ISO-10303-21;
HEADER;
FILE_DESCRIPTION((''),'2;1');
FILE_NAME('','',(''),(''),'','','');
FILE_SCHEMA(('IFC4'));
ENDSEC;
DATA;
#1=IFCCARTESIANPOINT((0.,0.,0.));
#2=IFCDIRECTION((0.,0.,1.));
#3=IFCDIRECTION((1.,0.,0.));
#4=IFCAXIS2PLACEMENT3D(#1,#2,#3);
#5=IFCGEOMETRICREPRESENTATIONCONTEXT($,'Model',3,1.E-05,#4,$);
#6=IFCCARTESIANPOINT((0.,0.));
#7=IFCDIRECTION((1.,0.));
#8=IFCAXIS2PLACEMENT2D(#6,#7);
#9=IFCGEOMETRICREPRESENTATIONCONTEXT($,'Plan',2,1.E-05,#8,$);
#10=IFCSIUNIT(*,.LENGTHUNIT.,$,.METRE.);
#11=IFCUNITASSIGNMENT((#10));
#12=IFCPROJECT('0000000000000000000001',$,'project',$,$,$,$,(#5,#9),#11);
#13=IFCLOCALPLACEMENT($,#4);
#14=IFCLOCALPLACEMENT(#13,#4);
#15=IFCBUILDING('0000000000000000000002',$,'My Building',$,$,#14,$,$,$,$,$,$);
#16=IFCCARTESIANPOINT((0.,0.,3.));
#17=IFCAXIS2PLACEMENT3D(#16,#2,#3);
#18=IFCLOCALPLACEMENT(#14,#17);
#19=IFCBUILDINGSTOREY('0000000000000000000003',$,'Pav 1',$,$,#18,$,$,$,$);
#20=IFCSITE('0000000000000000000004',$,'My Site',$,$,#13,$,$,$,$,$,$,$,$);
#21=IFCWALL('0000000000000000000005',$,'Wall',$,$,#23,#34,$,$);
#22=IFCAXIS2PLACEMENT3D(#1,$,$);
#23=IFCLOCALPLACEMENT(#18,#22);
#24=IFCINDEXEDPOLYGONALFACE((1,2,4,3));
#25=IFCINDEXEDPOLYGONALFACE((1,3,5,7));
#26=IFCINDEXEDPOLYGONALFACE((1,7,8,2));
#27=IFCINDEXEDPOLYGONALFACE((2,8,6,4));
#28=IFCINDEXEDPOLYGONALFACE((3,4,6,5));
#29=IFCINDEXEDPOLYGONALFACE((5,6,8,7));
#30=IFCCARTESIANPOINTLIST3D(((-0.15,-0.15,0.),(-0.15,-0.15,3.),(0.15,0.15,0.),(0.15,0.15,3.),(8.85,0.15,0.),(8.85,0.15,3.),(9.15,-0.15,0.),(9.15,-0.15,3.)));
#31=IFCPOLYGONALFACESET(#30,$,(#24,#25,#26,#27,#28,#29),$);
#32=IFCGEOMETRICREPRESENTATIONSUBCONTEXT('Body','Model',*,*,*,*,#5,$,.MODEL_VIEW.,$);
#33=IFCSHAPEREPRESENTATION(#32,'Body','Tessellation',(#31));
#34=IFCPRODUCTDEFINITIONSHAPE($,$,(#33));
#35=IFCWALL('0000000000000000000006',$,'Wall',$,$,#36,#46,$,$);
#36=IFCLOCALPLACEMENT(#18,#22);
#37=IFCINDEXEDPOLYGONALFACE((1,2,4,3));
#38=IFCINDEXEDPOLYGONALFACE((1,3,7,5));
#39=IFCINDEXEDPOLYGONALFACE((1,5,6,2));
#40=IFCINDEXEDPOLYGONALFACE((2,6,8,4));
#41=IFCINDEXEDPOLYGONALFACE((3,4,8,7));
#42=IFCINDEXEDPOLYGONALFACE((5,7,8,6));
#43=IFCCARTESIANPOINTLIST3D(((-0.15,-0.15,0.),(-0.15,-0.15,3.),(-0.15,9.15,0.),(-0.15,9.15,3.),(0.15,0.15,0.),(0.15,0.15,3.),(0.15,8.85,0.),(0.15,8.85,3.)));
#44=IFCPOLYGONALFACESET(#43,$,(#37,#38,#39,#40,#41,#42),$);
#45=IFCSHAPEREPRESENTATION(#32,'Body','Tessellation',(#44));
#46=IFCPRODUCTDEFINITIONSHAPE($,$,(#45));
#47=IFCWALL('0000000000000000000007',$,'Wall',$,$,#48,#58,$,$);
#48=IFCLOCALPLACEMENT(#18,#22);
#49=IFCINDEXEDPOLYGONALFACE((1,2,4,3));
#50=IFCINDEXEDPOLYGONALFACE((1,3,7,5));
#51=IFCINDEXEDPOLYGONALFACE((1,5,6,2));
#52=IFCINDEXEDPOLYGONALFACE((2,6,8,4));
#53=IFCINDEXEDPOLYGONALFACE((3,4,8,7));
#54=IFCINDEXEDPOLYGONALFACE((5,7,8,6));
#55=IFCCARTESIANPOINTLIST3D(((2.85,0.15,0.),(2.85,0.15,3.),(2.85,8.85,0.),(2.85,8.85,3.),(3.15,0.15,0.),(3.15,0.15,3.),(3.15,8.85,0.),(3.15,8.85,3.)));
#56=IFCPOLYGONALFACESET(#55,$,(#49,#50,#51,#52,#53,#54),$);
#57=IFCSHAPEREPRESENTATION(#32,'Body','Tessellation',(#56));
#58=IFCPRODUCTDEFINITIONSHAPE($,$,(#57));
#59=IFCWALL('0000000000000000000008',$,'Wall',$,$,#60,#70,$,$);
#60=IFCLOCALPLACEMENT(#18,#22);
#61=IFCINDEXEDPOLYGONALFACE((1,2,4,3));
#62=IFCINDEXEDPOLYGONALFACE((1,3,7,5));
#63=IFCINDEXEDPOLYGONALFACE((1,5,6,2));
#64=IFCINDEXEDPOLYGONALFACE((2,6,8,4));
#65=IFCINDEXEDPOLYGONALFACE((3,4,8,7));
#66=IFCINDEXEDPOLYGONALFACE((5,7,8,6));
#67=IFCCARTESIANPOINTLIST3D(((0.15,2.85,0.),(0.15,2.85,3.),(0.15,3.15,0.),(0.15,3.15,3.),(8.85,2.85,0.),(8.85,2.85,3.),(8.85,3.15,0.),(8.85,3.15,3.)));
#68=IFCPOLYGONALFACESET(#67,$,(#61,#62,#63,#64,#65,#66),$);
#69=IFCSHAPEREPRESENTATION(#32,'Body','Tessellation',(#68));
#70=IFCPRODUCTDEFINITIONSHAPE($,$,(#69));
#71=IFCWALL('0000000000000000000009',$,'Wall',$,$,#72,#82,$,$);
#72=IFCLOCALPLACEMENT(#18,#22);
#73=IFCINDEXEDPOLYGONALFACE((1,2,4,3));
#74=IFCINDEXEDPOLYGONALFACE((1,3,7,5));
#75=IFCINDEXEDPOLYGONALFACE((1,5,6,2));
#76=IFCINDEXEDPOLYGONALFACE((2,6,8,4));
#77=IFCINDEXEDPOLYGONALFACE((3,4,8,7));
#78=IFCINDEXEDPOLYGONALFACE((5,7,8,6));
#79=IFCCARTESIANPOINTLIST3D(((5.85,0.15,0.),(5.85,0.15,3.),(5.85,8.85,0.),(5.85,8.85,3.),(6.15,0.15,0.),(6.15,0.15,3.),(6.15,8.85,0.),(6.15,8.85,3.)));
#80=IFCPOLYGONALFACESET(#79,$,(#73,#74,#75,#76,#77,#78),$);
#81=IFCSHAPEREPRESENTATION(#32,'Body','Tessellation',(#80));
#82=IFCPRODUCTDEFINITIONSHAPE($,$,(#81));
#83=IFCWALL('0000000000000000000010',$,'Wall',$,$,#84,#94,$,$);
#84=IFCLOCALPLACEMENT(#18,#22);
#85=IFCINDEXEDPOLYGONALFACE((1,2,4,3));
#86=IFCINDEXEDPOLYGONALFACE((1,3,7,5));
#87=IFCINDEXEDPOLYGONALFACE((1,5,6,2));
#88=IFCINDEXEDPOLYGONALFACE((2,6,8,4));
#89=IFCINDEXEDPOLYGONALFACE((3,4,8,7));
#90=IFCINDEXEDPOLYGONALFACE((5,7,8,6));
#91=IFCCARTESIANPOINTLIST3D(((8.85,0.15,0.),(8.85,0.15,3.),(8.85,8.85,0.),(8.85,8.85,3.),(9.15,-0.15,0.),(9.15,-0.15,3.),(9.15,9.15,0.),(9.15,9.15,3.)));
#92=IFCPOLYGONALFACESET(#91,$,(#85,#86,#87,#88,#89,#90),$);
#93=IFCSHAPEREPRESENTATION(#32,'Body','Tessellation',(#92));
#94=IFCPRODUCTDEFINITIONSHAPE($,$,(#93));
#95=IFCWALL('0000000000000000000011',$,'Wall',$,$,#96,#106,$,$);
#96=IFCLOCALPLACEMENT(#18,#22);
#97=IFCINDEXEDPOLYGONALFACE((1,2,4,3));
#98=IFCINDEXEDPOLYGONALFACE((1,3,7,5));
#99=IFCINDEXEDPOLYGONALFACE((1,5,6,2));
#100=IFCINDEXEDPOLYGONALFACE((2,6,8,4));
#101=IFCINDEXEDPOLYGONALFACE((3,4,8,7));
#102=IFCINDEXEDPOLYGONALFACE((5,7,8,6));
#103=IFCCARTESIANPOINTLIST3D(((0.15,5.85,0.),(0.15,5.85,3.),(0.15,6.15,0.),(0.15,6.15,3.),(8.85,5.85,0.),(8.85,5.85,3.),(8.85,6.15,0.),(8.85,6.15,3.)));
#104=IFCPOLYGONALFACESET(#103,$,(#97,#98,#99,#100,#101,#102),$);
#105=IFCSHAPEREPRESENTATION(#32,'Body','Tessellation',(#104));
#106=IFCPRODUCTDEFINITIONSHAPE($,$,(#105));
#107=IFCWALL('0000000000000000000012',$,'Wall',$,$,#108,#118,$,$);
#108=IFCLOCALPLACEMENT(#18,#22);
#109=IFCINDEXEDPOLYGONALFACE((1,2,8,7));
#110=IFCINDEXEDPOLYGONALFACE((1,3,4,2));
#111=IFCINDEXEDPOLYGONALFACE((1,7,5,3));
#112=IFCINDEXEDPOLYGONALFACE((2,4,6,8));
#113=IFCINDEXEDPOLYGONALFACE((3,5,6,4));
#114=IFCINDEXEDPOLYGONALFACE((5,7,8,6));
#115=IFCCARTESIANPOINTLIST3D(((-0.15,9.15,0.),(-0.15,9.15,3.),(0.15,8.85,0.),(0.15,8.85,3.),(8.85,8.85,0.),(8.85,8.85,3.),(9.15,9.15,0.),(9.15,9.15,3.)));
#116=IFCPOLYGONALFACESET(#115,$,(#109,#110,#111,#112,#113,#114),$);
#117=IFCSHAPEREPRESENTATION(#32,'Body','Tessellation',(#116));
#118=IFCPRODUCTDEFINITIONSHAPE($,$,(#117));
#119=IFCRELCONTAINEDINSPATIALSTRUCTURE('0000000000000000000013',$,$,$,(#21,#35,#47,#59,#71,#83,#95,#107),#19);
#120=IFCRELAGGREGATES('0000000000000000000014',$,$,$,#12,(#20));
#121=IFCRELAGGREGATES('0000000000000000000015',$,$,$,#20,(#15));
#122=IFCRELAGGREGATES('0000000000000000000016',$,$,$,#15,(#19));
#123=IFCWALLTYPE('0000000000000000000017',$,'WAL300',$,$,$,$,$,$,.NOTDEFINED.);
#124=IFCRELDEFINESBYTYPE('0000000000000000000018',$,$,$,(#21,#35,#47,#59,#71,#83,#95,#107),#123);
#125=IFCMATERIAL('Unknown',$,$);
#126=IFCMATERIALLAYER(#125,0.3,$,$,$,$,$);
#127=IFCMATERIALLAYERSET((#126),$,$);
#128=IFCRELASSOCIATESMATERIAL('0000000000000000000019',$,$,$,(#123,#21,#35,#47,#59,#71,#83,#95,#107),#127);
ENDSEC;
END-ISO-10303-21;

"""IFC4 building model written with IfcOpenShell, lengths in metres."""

from ifc_helpers import new_model, si_unit, frame, origin_with_axes, origin_2d_with_axis, place, context, subcontext, project, spatial, line, indexed_curve, outline, extrude, material, layer, layer_set, layer_usage, type_object, element, save


model = new_model("IFC4")

# Units and contexts
model_context = context("Model", 3, precision=1e-05, world=origin_with_axes())
plan_context = context("Plan", 2, precision=1e-05, world=origin_2d_with_axis())
body_context = subcontext(model_context, "Body", "Model", "MODEL_VIEW")
ifc_project = project(units=[si_unit("LENGTHUNIT", "METRE")], contexts=[model_context, plan_context])

# Site, building, storey
site_placement = place(None, origin_with_axes())
site = spatial("IfcSite", under=ifc_project, at=site_placement, Name="My Site")
building_placement = place(site_placement, origin_with_axes())
building = spatial("IfcBuilding", under=site, at=building_placement, Name="My Building")
storey_placement = place(building_placement, frame((0.0, 0.0, 3.0), z_axis=(0.0, 0.0, 1.0), x_axis=(1.0, 0.0, 0.0)))
storey = spatial("IfcBuildingStorey", under=building, at=storey_placement, Name="Pav 1")

# Shared definitions
ifc_material = material(Name="Unknown")

# Walls
ifc_layer_1 = layer(ifc_material, 0.3)
ifc_layer_set_1 = layer_set([ifc_layer_1])
ifc_layer_usage_1 = layer_usage(ifc_layer_set_1, "AXIS2", "POSITIVE", -0.15)
wall_type = type_object("IfcWallType", Name="WAL300", PredefinedType="NOTDEFINED", material=ifc_layer_set_1)
wall_1_placement = place(storey_placement, frame((9.0, 0.0, 0.0), z_axis=(0.0, 0.0, 1.0), x_axis=(-1.0, 0.0, 0.0)))
element("IfcWall", 1, at=wall_1_placement, inside=storey, type_object=wall_type, material=ifc_layer_usage_1, Name="Wall", context=body_context, shape_type="SweptSolid", body=[
    extrude(outline(indexed_curve([(0.15, -0.15), (-0.15, 0.15), (9.15, 0.15), (8.85, -0.15)], segments=[line(1, 2, 3, 4, 1)])), origin_with_axes(), (0.0, 0.0, 1.0), 3.0),
])
ifc_layer_usage_2 = layer_usage(ifc_layer_set_1, "AXIS2", "POSITIVE", -0.15)
wall_2_placement = place(storey_placement, frame((0.0, 0.0, 0.0), z_axis=(0.0, 0.0, 1.0), x_axis=(0.0, 1.0, 0.0)))
element("IfcWall", 2, at=wall_2_placement, inside=storey, type_object=wall_type, material=ifc_layer_usage_2, Name="Wall", context=body_context, shape_type="SweptSolid", body=[
    extrude(outline(indexed_curve([(0.15, -0.15), (-0.15, 0.15), (9.15, 0.15), (8.85, -0.15)], segments=[line(1, 2, 3, 4, 1)])), origin_with_axes(), (0.0, 0.0, 1.0), 3.0),
])
ifc_layer_usage_3 = layer_usage(ifc_layer_set_1, "AXIS2", "POSITIVE", -0.15)
wall_3_placement = place(storey_placement, frame((3.0, 9.0, 0.0), z_axis=(0.0, 0.0, 1.0), x_axis=(0.0, -1.0, 0.0)))
element("IfcWall", 3, at=wall_3_placement, inside=storey, type_object=wall_type, material=ifc_layer_usage_3, Name="Wall", context=body_context, shape_type="SweptSolid", body=[
    extrude(outline(indexed_curve([(0.15, -0.15), (0.15, 0.15), (8.85, 0.15), (8.85, -0.15)], segments=[line(1, 2, 3, 4, 1)])), origin_with_axes(), (0.0, 0.0, 1.0), 3.0),
])
ifc_layer_usage_4 = layer_usage(ifc_layer_set_1, "AXIS2", "POSITIVE", -0.15)
wall_4_placement = place(storey_placement, frame((0.0, 3.0, 0.0), z_axis=(0.0, 0.0, 1.0), x_axis=(1.0, 0.0, 0.0)))
element("IfcWall", 4, at=wall_4_placement, inside=storey, type_object=wall_type, material=ifc_layer_usage_4, Name="Wall", context=body_context, shape_type="SweptSolid", body=[
    extrude(outline(indexed_curve([(0.15, -0.15), (0.15, 0.15), (8.85, 0.15), (8.85, -0.15)], segments=[line(1, 2, 3, 4, 1)])), origin_with_axes(), (0.0, 0.0, 1.0), 3.0),
])
ifc_layer_usage_5 = layer_usage(ifc_layer_set_1, "AXIS2", "POSITIVE", -0.15)
wall_5_placement = place(storey_placement, frame((6.0, 9.0, 0.0), z_axis=(0.0, 0.0, 1.0), x_axis=(0.0, -1.0, 0.0)))
element("IfcWall", 5, at=wall_5_placement, inside=storey, type_object=wall_type, material=ifc_layer_usage_5, Name="Wall", context=body_context, shape_type="SweptSolid", body=[
    extrude(outline(indexed_curve([(0.15, -0.15), (0.15, 0.15), (8.85, 0.15), (8.85, -0.15)], segments=[line(1, 2, 3, 4, 1)])), origin_with_axes(), (0.0, 0.0, 1.0), 3.0),
])
ifc_layer_usage_6 = layer_usage(ifc_layer_set_1, "AXIS2", "POSITIVE", -0.15)
wall_6_placement = place(storey_placement, frame((9.0, 9.0, 0.0), z_axis=(0.0, 0.0, 1.0), x_axis=(0.0, -1.0, 0.0)))
element("IfcWall", 6, at=wall_6_placement, inside=storey, type_object=wall_type, material=ifc_layer_usage_6, Name="Wall", context=body_context, shape_type="SweptSolid", body=[
    extrude(outline(indexed_curve([(0.15, -0.15), (-0.15, 0.15), (9.15, 0.15), (8.85, -0.15)], segments=[line(1, 2, 3, 4, 1)])), origin_with_axes(), (0.0, 0.0, 1.0), 3.0),
])
ifc_layer_usage_7 = layer_usage(ifc_layer_set_1, "AXIS2", "POSITIVE", -0.15)
wall_7_placement = place(storey_placement, frame((0.0, 6.0, 0.0), z_axis=(0.0, 0.0, 1.0), x_axis=(1.0, 0.0, 0.0)))
element("IfcWall", 7, at=wall_7_placement, inside=storey, type_object=wall_type, material=ifc_layer_usage_7, Name="Wall", context=body_context, shape_type="SweptSolid", body=[
    extrude(outline(indexed_curve([(0.15, -0.15), (0.15, 0.15), (8.85, 0.15), (8.85, -0.15)], segments=[line(1, 2, 3, 4, 1)])), origin_with_axes(), (0.0, 0.0, 1.0), 3.0),
])
ifc_layer_usage_8 = layer_usage(ifc_layer_set_1, "AXIS2", "POSITIVE", -0.15)
wall_8_placement = place(storey_placement, frame((0.0, 9.0, 0.0), z_axis=(0.0, 0.0, 1.0), x_axis=(1.0, 0.0, 0.0)))
element("IfcWall", 8, at=wall_8_placement, inside=storey, type_object=wall_type, material=ifc_layer_usage_8, Name="Wall", context=body_context, shape_type="SweptSolid", body=[
    extrude(outline(indexed_curve([(0.15, -0.15), (-0.15, 0.15), (9.15, 0.15), (8.85, -0.15)], segments=[line(1, 2, 3, 4, 1)])), origin_with_axes(), (0.0, 0.0, 1.0), 3.0),
])

save(model, "model.ifc")
